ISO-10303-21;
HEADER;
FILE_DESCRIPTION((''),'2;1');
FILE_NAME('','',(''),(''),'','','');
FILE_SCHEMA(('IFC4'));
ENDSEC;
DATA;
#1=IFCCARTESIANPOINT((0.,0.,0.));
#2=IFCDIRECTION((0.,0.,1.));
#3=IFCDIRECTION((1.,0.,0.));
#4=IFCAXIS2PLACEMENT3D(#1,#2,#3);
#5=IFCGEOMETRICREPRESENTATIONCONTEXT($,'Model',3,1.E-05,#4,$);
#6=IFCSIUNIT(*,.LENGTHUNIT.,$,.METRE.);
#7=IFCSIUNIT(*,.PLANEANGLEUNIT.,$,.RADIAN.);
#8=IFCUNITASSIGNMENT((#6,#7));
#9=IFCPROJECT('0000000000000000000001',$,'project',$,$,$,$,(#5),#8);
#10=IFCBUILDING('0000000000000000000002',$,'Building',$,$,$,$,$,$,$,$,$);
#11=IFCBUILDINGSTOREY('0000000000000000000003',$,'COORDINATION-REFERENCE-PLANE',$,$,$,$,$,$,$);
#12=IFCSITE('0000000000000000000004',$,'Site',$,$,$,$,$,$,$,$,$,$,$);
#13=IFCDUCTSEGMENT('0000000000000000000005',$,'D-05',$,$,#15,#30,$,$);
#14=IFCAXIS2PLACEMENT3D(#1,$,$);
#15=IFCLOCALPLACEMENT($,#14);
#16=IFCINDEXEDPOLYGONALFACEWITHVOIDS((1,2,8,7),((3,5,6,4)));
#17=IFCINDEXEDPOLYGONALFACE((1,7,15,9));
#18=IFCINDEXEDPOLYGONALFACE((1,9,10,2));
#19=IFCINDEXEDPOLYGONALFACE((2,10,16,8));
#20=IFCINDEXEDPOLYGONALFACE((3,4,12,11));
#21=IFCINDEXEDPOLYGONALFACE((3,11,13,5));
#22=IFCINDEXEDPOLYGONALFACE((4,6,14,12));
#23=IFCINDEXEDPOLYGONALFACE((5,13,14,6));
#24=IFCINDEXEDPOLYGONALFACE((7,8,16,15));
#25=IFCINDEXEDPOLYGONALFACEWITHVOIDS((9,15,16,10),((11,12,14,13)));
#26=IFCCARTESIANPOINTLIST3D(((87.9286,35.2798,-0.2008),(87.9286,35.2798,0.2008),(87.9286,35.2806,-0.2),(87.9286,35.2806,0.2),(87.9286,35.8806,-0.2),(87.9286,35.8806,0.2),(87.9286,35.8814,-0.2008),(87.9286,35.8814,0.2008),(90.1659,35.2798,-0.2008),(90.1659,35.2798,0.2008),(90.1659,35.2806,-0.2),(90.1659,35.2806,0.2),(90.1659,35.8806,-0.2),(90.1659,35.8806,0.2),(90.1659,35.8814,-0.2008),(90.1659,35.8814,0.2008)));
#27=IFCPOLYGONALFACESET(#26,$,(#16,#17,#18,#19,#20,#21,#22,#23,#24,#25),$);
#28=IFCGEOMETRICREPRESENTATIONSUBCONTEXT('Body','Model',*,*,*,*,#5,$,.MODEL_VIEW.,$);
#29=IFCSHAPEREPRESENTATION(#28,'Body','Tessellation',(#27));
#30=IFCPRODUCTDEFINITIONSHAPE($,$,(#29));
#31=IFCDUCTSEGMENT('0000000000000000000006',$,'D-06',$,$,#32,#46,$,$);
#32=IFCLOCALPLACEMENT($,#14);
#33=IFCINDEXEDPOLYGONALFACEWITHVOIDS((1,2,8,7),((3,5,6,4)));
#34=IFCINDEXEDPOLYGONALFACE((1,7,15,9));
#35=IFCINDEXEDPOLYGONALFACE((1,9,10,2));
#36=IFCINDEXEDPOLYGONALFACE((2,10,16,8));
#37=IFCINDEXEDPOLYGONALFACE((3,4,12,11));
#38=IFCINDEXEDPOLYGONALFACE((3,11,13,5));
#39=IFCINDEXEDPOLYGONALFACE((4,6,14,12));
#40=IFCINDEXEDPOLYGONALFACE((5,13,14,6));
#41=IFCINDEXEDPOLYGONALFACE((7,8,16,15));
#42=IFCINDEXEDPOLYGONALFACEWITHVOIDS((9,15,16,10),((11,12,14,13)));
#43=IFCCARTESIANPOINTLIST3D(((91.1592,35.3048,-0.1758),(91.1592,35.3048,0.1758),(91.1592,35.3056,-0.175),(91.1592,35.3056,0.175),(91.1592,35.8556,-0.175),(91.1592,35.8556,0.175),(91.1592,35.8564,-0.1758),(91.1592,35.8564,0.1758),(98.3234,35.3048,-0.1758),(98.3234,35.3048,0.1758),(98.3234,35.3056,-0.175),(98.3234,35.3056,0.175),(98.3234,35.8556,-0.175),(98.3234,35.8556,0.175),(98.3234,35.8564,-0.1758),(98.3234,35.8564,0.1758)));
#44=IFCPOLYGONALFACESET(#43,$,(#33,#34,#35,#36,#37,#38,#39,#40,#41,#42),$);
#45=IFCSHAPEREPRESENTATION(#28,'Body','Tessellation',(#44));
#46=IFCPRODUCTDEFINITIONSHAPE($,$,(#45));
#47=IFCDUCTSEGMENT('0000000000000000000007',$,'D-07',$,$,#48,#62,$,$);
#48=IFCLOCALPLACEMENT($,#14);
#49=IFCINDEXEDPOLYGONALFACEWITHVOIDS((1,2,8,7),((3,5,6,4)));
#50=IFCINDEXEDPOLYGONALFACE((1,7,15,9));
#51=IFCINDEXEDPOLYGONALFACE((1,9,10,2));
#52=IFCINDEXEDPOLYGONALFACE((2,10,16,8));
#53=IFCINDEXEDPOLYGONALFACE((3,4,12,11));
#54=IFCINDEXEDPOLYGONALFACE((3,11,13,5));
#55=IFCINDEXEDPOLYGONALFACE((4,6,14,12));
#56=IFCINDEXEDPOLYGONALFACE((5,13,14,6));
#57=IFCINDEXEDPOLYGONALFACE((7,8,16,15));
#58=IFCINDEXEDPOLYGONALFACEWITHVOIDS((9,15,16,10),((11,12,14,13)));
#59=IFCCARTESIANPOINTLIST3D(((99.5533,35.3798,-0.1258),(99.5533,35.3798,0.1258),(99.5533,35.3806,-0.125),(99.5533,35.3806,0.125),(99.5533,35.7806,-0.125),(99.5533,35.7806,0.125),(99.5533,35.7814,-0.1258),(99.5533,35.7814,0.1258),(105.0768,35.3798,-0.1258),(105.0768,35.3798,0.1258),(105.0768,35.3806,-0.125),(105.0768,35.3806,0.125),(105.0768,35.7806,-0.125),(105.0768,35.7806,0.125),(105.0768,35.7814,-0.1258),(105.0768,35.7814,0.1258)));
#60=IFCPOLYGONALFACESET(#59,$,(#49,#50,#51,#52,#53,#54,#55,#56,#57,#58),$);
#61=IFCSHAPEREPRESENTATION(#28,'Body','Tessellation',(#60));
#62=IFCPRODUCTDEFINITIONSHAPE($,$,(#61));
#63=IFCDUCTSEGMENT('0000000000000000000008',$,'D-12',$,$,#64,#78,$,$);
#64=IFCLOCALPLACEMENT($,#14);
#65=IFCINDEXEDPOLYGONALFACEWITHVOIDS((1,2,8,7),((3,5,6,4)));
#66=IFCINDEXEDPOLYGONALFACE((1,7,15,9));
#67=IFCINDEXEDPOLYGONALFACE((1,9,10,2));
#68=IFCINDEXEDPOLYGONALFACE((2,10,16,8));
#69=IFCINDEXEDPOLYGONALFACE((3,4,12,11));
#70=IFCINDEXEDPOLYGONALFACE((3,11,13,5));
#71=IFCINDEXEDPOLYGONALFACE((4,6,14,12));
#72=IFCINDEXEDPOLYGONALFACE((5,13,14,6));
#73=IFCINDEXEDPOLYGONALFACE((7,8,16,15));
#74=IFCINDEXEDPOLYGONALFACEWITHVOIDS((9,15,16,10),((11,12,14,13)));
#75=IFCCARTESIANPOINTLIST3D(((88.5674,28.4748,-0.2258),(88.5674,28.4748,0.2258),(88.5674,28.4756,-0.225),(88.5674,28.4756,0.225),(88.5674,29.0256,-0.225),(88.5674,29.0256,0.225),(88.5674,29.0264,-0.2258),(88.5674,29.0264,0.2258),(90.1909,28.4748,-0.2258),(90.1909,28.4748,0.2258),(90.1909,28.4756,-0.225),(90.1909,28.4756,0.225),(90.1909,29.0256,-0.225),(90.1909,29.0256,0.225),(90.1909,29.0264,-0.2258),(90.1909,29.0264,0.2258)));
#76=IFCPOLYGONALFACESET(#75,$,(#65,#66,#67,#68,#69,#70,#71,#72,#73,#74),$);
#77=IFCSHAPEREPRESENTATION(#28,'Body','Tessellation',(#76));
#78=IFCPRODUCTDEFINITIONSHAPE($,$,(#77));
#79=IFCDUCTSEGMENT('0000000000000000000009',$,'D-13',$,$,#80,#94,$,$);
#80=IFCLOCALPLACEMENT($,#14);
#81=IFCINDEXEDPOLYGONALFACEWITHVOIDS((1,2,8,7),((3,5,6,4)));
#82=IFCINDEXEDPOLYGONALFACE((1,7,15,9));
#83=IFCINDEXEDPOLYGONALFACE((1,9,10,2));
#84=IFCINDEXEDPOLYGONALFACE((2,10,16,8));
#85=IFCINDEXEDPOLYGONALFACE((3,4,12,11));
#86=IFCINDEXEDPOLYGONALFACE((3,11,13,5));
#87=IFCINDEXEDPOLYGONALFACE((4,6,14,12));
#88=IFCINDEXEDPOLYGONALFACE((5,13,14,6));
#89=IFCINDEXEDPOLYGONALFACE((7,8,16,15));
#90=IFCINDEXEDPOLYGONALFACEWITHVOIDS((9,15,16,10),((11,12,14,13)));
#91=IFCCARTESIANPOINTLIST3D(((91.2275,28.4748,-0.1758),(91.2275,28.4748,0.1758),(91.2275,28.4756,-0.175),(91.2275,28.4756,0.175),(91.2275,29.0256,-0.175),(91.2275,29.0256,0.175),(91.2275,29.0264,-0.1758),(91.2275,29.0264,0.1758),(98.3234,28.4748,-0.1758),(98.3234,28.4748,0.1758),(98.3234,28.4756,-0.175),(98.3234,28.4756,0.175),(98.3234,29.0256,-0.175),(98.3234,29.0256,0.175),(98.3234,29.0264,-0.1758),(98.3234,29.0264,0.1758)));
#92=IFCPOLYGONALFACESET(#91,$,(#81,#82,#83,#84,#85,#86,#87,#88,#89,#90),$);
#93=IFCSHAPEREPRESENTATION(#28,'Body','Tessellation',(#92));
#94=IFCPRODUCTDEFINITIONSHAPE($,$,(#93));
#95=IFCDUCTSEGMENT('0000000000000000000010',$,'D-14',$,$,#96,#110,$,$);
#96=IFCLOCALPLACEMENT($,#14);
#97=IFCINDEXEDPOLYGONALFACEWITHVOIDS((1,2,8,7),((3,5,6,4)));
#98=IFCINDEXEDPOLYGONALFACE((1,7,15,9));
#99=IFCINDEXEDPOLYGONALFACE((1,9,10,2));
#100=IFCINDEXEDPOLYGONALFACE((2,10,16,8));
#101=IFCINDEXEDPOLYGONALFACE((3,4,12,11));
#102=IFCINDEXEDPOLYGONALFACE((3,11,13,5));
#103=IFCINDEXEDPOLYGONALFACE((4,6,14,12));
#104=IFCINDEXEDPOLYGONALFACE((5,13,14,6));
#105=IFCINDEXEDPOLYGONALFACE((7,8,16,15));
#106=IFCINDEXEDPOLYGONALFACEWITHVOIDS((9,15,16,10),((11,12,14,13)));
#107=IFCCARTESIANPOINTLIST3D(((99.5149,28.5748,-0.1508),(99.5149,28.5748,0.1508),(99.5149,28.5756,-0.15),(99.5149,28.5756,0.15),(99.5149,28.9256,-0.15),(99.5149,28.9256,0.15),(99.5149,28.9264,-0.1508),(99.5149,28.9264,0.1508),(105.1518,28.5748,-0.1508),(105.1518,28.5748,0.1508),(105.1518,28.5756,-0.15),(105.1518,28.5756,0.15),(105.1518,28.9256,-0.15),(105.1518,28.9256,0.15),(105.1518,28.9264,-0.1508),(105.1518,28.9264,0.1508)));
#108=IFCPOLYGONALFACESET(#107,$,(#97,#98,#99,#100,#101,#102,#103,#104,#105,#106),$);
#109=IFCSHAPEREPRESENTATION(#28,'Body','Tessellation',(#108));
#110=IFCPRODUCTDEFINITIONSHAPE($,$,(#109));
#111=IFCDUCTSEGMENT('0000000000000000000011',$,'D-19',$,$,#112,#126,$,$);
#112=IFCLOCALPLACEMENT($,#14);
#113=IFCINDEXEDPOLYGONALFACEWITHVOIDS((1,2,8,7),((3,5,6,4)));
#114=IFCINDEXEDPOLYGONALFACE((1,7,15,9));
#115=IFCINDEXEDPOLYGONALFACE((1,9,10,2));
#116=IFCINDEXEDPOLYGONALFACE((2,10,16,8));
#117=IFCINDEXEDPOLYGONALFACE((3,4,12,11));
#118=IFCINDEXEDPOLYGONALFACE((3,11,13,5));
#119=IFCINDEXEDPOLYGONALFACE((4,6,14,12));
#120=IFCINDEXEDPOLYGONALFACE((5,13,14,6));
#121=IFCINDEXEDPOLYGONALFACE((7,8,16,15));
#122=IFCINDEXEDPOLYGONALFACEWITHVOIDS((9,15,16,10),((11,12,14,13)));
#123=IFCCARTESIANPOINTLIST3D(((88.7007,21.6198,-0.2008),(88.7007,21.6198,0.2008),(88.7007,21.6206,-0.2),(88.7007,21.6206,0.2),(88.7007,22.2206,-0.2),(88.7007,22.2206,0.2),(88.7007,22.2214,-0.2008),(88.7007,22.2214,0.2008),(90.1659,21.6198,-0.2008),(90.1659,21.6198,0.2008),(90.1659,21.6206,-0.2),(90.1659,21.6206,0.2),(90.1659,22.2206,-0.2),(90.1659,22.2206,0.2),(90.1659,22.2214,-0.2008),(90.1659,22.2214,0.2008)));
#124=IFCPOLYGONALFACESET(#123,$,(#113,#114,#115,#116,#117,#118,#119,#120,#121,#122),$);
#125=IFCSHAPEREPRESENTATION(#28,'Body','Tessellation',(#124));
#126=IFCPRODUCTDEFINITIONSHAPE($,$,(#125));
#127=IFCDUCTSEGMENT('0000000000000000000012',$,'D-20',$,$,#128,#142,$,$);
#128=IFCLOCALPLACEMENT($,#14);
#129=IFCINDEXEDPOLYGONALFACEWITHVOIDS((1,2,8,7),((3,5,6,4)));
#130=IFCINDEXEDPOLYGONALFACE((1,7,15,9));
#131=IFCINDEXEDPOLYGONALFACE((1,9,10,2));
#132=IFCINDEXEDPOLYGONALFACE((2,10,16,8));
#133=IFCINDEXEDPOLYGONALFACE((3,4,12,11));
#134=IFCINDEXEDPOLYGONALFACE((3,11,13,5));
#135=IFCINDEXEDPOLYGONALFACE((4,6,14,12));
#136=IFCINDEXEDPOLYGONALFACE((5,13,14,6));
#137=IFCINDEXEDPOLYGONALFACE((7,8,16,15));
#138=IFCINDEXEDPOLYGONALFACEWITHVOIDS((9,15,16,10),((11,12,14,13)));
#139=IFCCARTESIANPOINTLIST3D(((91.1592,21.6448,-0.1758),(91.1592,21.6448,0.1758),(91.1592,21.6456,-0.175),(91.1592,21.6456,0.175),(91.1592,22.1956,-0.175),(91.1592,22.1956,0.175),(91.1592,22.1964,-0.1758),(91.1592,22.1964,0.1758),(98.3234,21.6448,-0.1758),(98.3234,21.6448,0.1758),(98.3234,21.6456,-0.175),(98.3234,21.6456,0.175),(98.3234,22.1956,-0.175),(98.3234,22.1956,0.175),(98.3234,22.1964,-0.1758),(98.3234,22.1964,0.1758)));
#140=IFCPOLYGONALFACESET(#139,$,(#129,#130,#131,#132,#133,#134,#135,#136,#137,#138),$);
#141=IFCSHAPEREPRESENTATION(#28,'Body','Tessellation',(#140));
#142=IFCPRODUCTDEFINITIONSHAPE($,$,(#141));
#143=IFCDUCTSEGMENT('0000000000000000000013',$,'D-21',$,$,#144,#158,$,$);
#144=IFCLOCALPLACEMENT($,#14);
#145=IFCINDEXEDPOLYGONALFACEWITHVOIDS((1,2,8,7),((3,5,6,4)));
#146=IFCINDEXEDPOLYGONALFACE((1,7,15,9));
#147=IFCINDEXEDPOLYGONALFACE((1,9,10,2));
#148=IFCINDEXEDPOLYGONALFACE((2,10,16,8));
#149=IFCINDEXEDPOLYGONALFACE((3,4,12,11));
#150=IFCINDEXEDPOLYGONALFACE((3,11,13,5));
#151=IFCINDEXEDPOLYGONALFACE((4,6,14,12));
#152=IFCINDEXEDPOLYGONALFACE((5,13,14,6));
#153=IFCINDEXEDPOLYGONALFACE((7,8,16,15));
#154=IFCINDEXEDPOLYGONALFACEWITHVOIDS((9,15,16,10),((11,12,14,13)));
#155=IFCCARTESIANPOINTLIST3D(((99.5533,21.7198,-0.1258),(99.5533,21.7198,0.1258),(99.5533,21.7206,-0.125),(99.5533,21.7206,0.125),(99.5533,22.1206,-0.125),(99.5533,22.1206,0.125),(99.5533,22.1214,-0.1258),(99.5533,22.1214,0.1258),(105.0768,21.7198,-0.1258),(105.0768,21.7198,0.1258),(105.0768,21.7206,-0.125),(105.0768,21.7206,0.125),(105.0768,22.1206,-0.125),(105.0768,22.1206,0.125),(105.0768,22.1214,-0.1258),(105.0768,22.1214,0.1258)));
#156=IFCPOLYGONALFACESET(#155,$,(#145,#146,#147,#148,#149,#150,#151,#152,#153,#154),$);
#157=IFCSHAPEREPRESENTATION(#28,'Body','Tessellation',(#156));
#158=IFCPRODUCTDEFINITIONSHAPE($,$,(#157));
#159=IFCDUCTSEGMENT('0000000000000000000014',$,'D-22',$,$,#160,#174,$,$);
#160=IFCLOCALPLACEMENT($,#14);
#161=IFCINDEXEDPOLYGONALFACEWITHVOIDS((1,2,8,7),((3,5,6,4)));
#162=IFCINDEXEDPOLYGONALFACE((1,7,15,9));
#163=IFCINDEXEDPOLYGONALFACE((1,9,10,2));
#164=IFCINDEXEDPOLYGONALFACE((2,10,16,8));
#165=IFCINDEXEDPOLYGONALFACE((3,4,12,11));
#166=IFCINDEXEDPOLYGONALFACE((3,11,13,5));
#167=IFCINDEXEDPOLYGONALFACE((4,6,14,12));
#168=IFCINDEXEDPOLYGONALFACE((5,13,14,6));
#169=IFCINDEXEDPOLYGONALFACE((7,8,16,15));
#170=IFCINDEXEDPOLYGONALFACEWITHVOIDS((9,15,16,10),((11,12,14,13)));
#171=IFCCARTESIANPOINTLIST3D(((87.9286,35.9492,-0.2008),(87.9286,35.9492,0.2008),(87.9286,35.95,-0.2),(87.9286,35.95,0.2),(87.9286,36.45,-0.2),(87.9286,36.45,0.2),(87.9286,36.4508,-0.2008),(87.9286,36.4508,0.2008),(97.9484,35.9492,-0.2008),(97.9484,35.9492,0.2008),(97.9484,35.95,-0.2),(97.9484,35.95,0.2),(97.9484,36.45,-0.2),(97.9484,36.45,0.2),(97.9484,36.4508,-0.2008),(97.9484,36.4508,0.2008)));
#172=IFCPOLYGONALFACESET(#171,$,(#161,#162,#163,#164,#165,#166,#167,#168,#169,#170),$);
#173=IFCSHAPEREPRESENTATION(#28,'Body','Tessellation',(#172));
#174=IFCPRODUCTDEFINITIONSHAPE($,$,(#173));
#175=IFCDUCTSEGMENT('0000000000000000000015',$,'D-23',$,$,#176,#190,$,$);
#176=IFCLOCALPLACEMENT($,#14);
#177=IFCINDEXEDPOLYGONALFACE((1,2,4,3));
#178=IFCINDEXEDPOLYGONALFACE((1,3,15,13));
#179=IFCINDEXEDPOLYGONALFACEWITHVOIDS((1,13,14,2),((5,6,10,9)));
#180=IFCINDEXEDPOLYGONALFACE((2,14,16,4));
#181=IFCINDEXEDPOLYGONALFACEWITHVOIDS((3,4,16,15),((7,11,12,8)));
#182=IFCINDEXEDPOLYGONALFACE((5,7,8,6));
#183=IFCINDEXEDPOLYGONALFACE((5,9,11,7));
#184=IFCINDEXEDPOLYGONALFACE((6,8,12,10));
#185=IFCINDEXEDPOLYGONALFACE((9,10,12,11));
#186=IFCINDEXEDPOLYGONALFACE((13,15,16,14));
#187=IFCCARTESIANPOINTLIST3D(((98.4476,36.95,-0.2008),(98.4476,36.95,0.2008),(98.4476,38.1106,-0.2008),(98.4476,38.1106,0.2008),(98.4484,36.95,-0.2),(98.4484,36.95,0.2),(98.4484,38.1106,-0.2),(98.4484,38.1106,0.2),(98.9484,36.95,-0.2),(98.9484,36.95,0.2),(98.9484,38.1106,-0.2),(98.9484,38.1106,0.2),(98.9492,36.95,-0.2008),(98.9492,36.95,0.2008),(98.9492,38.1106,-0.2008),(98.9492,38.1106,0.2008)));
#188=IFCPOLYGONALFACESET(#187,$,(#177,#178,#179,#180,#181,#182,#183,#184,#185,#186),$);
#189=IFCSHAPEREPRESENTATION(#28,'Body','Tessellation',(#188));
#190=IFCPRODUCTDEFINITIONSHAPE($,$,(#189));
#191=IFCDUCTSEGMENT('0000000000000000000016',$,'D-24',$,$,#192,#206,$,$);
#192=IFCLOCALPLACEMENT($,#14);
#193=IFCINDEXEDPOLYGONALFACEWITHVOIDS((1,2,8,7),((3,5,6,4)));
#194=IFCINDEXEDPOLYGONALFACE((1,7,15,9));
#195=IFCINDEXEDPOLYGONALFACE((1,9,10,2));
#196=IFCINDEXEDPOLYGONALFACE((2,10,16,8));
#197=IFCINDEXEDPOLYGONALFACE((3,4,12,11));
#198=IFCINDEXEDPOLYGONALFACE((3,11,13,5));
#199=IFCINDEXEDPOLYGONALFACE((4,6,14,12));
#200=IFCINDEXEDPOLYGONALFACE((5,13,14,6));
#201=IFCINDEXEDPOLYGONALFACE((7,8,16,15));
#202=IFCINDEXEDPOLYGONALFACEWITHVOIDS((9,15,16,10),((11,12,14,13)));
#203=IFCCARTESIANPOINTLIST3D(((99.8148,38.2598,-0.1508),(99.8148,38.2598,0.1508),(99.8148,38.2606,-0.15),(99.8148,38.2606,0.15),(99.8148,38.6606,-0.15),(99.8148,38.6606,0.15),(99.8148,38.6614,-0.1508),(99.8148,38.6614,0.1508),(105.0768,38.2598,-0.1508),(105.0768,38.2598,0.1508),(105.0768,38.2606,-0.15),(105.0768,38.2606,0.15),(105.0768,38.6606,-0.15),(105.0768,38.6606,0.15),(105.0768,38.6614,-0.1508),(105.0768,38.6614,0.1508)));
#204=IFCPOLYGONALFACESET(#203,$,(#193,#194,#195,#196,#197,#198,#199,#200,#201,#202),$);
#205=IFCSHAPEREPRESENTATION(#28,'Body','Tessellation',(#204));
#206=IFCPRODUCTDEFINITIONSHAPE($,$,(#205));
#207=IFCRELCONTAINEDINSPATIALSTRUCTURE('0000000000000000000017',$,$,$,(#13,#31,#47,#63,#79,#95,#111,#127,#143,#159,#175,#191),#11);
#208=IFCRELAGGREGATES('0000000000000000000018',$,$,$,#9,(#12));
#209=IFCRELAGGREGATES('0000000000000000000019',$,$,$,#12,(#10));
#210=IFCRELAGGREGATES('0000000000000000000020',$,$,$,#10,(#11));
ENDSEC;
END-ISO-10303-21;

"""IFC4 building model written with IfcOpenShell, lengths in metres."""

from ifc_helpers import new_model, si_unit, frame, origin, origin_with_axes, place, context, subcontext, project, spatial, hollow_rectangle, extrude, element, save


model = new_model("IFC4")

# Units and contexts
model_context = context("Model", 3, precision=1e-05, world=origin_with_axes())
body_context = subcontext(model_context, "Body", "Model", "MODEL_VIEW")
ifc_project = project(units=[si_unit("LENGTHUNIT", "METRE"), si_unit("PLANEANGLEUNIT", "RADIAN")], contexts=[model_context])

# Site, building, storey
site = spatial("IfcSite", under=ifc_project, Name="Site")
building = spatial("IfcBuilding", under=site, Name="Building")
storey = spatial("IfcBuildingStorey", under=building, Name="COORDINATION-REFERENCE-PLANE")

# Duct segments
duct_segment_1_placement = place(None, frame((87.9286, 35.5806, 0.0), z_axis=(1.0, 0.0, 0.0), x_axis=(0.0, 1.0, 0.0)))
element("IfcDuctSegment", 1, at=duct_segment_1_placement, inside=storey, Name="D-05", context=body_context, shape_type="SweptSolid", body=[
    extrude(hollow_rectangle(XDim=0.6016, YDim=0.4016, WallThickness=0.0008), origin(), (0.0, 0.0, 1.0), 2.2374),
])
duct_segment_2_placement = place(None, frame((91.1592, 35.5806, 0.0), z_axis=(1.0, 0.0, 0.0), x_axis=(0.0, 1.0, 0.0)))
element("IfcDuctSegment", 2, at=duct_segment_2_placement, inside=storey, Name="D-06", context=body_context, shape_type="SweptSolid", body=[
    extrude(hollow_rectangle(XDim=0.5516, YDim=0.3516, WallThickness=0.0008), origin(), (0.0, 0.0, 1.0), 7.1642),
])
duct_segment_3_placement = place(None, frame((99.5533, 35.5806, 0.0), z_axis=(1.0, 0.0, 0.0), x_axis=(0.0, 1.0, 0.0)))
element("IfcDuctSegment", 3, at=duct_segment_3_placement, inside=storey, Name="D-07", context=body_context, shape_type="SweptSolid", body=[
    extrude(hollow_rectangle(XDim=0.4016, YDim=0.2516, WallThickness=0.0008), origin(), (0.0, 0.0, 1.0), 5.5234),
])
duct_segment_4_placement = place(None, frame((88.5674, 28.7506, 0.0), z_axis=(1.0, 0.0, 0.0), x_axis=(0.0, 1.0, 0.0)))
element("IfcDuctSegment", 4, at=duct_segment_4_placement, inside=storey, Name="D-12", context=body_context, shape_type="SweptSolid", body=[
    extrude(hollow_rectangle(XDim=0.5516, YDim=0.4516, WallThickness=0.0008), origin(), (0.0, 0.0, 1.0), 1.6235),
])
duct_segment_5_placement = place(None, frame((91.2275, 28.7506, 0.0), z_axis=(1.0, 0.0, 0.0), x_axis=(0.0, 1.0, 0.0)))
element("IfcDuctSegment", 5, at=duct_segment_5_placement, inside=storey, Name="D-13", context=body_context, shape_type="SweptSolid", body=[
    extrude(hollow_rectangle(XDim=0.5516, YDim=0.3516, WallThickness=0.0008), origin(), (0.0, 0.0, 1.0), 7.0959),
])
duct_segment_6_placement = place(None, frame((99.5149, 28.7506, 0.0), z_axis=(1.0, 0.0, 0.0), x_axis=(0.0, 1.0, 0.0)))
element("IfcDuctSegment", 6, at=duct_segment_6_placement, inside=storey, Name="D-14", context=body_context, shape_type="SweptSolid", body=[
    extrude(hollow_rectangle(XDim=0.3516, YDim=0.3016, WallThickness=0.0008), origin(), (0.0, 0.0, 1.0), 5.6369),
])
duct_segment_7_placement = place(None, frame((88.7007, 21.9206, 0.0), z_axis=(1.0, 0.0, 0.0), x_axis=(0.0, 1.0, 0.0)))
element("IfcDuctSegment", 7, at=duct_segment_7_placement, inside=storey, Name="D-19", context=body_context, shape_type="SweptSolid", body=[
    extrude(hollow_rectangle(XDim=0.6016, YDim=0.4016, WallThickness=0.0008), origin(), (0.0, 0.0, 1.0), 1.4652),
])
duct_segment_8_placement = place(None, frame((91.1592, 21.9206, 0.0), z_axis=(1.0, 0.0, 0.0), x_axis=(0.0, 1.0, 0.0)))
element("IfcDuctSegment", 8, at=duct_segment_8_placement, inside=storey, Name="D-20", context=body_context, shape_type="SweptSolid", body=[
    extrude(hollow_rectangle(XDim=0.5516, YDim=0.3516, WallThickness=0.0008), origin(), (0.0, 0.0, 1.0), 7.1642),
])
duct_segment_9_placement = place(None, frame((99.5533, 21.9206, 0.0), z_axis=(1.0, 0.0, 0.0), x_axis=(0.0, 1.0, 0.0)))
element("IfcDuctSegment", 9, at=duct_segment_9_placement, inside=storey, Name="D-21", context=body_context, shape_type="SweptSolid", body=[
    extrude(hollow_rectangle(XDim=0.4016, YDim=0.2516, WallThickness=0.0008), origin(), (0.0, 0.0, 1.0), 5.5234),
])
duct_segment_10_placement = place(None, frame((87.9286, 36.2, 0.0), z_axis=(1.0, 0.0, 0.0), x_axis=(0.0, 1.0, 0.0)))
element("IfcDuctSegment", 10, at=duct_segment_10_placement, inside=storey, Name="D-22", context=body_context, shape_type="SweptSolid", body=[
    extrude(hollow_rectangle(XDim=0.5016, YDim=0.4016, WallThickness=0.0008), origin(), (0.0, 0.0, 1.0), 10.0199),
])
duct_segment_11_placement = place(None, frame((98.6984, 36.95, 0.0), z_axis=(0.0, 1.0, 0.0), x_axis=(1.0, 0.0, 0.0)))
element("IfcDuctSegment", 11, at=duct_segment_11_placement, inside=storey, Name="D-23", context=body_context, shape_type="SweptSolid", body=[
    extrude(hollow_rectangle(XDim=0.5016, YDim=0.4016, WallThickness=0.0008), origin(), (0.0, 0.0, 1.0), 1.1606),
])
duct_segment_12_placement = place(None, frame((99.8148, 38.4606, 0.0), z_axis=(1.0, 0.0, 0.0), x_axis=(0.0, 1.0, 0.0)))
element("IfcDuctSegment", 12, at=duct_segment_12_placement, inside=storey, Name="D-24", context=body_context, shape_type="SweptSolid", body=[
    extrude(hollow_rectangle(XDim=0.4016, YDim=0.3016, WallThickness=0.0008), origin(), (0.0, 0.0, 1.0), 5.2619),
])

save(model, "model.ifc")
